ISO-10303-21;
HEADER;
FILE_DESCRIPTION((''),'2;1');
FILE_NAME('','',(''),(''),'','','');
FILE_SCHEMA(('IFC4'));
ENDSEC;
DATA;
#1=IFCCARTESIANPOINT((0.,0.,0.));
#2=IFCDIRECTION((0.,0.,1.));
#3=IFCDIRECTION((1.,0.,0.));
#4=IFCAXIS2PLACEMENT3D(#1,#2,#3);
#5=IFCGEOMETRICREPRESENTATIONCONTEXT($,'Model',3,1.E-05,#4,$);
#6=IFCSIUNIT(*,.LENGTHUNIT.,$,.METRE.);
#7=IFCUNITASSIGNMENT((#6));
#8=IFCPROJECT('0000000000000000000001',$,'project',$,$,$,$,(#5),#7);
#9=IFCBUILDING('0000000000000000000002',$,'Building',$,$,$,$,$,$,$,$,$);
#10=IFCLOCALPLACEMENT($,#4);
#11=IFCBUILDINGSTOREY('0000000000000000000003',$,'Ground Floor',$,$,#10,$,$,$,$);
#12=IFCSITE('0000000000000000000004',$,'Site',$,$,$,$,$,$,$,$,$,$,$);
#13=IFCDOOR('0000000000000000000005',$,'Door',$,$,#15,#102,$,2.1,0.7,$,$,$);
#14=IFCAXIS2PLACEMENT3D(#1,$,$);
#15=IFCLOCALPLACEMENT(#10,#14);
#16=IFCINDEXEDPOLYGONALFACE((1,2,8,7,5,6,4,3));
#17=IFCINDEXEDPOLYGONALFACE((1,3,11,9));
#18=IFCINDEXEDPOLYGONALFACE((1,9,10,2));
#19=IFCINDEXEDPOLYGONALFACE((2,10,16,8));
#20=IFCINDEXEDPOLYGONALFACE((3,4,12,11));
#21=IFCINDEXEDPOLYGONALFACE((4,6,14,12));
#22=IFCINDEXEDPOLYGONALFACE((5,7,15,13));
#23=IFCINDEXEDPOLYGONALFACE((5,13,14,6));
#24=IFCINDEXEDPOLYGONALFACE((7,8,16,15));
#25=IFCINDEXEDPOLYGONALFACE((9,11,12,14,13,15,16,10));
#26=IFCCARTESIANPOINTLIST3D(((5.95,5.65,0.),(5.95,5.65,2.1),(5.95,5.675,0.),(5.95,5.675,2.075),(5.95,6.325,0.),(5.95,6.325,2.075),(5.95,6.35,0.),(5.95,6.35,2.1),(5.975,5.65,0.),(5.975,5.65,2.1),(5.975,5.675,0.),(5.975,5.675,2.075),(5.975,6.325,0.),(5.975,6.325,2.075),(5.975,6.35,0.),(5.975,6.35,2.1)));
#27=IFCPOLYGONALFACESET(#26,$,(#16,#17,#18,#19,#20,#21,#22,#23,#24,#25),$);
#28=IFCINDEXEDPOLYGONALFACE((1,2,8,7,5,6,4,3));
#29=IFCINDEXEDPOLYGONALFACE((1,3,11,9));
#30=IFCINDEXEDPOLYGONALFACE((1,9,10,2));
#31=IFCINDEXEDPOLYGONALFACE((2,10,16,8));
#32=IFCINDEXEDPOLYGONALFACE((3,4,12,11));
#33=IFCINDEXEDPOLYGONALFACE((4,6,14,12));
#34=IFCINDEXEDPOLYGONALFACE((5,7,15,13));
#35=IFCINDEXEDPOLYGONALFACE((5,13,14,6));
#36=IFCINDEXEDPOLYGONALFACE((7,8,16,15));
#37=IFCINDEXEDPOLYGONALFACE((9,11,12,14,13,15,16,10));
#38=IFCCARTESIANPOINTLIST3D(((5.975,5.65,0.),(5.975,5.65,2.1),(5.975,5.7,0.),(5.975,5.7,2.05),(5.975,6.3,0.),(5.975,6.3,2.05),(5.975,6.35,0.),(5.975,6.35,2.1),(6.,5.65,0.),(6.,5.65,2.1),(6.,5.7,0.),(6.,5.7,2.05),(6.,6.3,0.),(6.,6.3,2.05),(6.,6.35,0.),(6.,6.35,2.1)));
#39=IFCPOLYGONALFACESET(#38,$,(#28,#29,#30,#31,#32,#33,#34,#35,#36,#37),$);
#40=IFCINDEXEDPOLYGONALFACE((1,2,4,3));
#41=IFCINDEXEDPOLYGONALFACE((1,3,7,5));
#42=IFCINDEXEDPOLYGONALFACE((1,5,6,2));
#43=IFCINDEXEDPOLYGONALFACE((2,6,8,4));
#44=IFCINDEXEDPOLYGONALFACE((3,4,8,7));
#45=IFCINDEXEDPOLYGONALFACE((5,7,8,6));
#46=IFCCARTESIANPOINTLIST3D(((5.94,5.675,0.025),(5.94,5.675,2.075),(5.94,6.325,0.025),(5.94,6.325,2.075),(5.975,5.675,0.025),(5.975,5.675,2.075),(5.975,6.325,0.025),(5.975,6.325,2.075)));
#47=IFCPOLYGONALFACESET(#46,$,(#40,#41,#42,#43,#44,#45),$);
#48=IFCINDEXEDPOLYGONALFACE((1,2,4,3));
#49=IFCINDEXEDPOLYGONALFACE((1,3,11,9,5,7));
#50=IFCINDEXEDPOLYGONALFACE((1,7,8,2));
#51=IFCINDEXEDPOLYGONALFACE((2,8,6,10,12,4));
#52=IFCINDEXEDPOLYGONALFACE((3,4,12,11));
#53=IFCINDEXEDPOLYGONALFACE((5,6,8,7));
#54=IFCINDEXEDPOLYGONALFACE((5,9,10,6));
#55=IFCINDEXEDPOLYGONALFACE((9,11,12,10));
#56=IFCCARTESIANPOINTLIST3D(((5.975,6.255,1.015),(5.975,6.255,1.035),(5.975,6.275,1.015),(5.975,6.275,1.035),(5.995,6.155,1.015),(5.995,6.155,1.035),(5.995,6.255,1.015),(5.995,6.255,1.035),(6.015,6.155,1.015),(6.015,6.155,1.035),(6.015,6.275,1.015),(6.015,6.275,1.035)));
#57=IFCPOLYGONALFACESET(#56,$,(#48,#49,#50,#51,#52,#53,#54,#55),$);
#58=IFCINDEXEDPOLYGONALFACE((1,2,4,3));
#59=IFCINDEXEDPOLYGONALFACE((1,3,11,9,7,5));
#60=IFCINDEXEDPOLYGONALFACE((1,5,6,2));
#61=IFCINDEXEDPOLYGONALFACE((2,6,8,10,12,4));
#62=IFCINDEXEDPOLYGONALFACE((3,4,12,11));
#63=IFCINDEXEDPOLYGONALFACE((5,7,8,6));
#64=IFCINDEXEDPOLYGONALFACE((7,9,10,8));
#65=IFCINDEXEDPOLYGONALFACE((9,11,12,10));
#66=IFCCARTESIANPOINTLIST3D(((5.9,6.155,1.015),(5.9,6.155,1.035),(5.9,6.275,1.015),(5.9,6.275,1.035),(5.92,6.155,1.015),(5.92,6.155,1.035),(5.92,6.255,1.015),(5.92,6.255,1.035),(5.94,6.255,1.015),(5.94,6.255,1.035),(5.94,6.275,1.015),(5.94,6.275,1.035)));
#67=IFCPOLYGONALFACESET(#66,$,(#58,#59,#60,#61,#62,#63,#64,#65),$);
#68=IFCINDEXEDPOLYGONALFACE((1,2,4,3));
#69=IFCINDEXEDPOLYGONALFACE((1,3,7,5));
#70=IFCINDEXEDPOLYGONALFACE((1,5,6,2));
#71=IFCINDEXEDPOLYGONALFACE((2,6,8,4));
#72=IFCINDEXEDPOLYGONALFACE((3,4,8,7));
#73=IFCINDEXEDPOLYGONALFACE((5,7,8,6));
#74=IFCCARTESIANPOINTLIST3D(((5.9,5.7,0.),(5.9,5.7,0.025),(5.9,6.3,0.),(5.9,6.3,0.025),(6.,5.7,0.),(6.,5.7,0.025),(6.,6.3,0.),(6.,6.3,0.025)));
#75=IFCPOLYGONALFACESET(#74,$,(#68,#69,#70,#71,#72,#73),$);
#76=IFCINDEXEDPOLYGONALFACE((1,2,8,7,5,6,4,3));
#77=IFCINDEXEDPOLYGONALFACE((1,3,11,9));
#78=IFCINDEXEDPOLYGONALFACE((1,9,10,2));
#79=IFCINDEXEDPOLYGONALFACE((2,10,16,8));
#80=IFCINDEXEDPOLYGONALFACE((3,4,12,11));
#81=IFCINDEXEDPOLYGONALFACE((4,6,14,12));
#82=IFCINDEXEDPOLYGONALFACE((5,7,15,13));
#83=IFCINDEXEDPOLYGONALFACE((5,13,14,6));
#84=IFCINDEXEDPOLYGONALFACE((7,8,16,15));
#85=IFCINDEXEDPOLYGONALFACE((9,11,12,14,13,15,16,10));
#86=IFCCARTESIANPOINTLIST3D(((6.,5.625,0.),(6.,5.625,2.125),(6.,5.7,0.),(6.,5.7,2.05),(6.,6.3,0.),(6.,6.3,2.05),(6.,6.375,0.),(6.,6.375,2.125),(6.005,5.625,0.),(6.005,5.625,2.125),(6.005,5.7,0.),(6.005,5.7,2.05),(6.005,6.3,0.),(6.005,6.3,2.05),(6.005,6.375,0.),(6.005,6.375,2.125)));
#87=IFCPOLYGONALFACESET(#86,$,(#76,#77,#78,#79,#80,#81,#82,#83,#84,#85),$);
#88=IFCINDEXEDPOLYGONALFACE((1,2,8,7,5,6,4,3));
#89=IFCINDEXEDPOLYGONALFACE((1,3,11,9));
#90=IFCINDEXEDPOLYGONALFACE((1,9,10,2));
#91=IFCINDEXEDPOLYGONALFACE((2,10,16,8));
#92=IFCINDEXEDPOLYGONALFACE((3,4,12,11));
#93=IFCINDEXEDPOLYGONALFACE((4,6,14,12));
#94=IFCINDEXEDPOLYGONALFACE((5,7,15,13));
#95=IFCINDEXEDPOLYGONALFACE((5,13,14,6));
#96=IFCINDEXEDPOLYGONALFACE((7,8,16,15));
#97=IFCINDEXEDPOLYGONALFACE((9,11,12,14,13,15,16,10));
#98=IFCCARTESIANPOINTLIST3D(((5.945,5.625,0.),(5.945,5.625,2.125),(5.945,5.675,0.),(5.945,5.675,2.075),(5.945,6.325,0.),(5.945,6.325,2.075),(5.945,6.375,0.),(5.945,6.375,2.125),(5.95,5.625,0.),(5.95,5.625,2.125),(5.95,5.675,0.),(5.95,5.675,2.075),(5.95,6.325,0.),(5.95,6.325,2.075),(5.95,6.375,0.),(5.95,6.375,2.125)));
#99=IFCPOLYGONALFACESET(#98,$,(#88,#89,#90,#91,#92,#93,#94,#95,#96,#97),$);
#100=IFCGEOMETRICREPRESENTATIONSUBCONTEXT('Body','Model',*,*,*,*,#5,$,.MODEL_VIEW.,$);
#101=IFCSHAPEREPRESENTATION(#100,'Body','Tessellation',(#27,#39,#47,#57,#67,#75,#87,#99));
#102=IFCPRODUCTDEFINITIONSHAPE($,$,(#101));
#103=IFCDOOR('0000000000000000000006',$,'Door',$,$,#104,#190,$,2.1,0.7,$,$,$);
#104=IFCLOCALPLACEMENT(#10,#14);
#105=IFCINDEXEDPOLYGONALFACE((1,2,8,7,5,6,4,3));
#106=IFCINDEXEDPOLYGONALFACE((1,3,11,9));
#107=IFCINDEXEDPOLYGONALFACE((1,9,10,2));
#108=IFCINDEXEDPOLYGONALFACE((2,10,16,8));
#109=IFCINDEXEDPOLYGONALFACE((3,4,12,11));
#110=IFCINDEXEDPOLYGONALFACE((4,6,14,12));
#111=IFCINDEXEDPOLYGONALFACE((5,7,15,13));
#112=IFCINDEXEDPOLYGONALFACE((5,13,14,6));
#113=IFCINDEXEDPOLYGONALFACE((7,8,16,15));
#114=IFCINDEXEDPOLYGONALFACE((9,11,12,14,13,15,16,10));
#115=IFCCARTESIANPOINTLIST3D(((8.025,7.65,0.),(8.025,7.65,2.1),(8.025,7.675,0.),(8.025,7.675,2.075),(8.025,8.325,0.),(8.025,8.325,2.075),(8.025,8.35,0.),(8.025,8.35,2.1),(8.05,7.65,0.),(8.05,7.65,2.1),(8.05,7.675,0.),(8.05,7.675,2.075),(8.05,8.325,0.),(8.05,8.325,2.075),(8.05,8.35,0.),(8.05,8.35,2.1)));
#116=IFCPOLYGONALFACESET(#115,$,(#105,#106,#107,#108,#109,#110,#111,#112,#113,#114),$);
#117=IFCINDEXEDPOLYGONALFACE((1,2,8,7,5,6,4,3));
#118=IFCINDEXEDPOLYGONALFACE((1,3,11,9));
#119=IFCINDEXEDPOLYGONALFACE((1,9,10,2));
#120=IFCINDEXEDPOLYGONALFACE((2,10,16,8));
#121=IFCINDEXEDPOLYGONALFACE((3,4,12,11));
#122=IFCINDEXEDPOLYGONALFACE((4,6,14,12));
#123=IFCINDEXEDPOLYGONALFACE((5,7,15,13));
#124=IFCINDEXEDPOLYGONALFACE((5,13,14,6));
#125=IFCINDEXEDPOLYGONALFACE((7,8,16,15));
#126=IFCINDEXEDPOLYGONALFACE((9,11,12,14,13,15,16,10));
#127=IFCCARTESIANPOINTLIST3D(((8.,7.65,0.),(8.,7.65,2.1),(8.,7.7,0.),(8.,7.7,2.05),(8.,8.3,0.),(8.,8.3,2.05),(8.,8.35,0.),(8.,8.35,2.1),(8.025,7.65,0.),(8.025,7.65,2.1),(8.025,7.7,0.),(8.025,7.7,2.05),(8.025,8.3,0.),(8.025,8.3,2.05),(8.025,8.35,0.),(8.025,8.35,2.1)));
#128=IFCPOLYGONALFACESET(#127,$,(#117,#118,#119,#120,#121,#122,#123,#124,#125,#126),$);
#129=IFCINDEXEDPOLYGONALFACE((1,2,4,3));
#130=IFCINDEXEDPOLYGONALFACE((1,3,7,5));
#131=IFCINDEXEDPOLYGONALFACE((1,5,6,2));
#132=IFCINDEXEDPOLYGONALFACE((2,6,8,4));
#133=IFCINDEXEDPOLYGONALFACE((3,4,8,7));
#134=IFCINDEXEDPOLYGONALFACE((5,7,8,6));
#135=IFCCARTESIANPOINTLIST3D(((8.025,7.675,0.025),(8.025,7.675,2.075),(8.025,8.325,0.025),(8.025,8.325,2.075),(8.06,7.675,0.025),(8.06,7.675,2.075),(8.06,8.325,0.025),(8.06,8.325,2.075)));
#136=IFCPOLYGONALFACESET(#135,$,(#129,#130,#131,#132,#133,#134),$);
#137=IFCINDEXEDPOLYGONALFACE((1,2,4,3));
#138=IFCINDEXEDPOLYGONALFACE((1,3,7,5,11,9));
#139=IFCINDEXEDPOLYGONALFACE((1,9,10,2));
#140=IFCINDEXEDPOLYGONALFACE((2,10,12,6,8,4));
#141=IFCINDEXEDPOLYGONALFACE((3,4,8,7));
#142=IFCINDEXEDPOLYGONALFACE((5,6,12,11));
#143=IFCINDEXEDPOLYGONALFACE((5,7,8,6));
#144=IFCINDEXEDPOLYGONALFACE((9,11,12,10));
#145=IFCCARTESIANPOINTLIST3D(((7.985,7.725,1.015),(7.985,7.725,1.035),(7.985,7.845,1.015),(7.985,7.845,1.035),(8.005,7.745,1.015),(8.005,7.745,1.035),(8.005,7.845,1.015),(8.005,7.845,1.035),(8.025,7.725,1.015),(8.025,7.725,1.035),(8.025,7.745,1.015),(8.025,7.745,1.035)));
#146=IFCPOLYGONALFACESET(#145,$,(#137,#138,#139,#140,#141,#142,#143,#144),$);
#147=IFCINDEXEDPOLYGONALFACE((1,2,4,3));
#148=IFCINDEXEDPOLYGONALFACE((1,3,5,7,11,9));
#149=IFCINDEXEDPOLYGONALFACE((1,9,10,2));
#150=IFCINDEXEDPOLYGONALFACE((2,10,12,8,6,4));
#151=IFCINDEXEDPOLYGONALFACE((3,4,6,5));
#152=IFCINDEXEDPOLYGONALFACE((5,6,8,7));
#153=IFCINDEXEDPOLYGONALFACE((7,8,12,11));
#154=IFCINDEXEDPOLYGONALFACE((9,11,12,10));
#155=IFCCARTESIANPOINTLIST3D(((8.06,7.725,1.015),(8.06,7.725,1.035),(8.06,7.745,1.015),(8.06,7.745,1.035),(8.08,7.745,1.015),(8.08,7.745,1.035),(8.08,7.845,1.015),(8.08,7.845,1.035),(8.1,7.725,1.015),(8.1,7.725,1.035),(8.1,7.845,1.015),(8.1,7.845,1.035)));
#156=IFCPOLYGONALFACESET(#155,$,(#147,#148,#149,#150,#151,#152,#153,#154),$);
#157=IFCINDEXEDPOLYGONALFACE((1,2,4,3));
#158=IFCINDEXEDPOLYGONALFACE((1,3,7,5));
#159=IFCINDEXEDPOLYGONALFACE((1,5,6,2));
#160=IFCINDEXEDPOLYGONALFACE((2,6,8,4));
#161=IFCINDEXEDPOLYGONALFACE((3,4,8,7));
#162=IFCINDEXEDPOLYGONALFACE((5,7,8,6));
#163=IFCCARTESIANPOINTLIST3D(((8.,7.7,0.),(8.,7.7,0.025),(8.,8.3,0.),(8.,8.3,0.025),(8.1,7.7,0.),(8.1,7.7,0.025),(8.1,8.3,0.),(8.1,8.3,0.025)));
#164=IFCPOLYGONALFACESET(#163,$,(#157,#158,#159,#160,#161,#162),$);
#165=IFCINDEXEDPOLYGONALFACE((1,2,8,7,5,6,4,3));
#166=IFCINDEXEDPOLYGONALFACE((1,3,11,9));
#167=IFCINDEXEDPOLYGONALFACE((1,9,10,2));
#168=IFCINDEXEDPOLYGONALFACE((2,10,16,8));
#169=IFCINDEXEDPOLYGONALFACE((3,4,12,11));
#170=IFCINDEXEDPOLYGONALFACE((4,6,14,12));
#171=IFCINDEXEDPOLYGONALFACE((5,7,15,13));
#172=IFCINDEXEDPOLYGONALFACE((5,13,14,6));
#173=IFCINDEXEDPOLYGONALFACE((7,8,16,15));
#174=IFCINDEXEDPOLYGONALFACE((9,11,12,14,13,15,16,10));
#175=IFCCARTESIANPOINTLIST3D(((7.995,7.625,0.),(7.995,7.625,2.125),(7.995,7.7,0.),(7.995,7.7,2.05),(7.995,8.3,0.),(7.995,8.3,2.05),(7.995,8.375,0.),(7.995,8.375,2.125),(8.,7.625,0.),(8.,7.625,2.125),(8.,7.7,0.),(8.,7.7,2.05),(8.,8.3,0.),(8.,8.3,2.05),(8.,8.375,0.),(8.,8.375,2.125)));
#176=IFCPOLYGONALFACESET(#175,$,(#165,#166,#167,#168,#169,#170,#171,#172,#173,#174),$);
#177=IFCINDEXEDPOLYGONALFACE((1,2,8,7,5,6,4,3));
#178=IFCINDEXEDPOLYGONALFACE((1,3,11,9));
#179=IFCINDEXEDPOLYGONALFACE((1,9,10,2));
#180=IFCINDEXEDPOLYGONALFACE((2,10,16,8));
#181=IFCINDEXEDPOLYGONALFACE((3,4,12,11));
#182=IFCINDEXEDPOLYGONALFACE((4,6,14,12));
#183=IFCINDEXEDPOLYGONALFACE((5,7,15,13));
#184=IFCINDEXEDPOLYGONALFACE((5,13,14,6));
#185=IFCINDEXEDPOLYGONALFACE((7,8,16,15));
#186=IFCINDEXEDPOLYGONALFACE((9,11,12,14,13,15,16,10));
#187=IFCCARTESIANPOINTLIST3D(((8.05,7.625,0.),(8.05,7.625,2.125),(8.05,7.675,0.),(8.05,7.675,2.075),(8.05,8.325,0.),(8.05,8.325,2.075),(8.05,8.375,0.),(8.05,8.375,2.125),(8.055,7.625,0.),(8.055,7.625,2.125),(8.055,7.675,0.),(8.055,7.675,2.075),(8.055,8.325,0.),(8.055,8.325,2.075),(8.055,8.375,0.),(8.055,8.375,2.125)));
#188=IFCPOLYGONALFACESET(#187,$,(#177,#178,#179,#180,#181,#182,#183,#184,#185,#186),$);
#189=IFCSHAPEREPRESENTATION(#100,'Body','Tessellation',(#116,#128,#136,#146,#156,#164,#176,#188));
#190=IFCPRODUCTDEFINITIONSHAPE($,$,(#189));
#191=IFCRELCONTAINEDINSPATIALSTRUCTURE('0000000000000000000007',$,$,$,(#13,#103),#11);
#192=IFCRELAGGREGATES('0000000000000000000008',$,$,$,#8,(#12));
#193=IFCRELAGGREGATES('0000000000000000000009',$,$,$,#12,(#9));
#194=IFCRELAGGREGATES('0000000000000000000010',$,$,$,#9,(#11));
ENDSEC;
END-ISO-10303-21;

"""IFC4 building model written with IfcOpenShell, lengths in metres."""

from ifc_helpers import new_model, si_unit, frame, origin_with_axes, place, context, subcontext, project, spatial, line, indexed_curve, outline, extrude, element, save


model = new_model("IFC4")

# Units and contexts
model_context = context("Model", 3, precision=1e-05, world=origin_with_axes())
body_context = subcontext(model_context, "Body", "Model", "MODEL_VIEW")
ifc_project = project(units=[si_unit("LENGTHUNIT", "METRE")], contexts=[model_context])

# Site, building, storey
site = spatial("IfcSite", under=ifc_project, Name="Site")
building = spatial("IfcBuilding", under=site, Name="Building")
storey_placement = place(None, origin_with_axes())
storey = spatial("IfcBuildingStorey", under=building, at=storey_placement, Name="Ground Floor")

# Doors
door_1_placement = place(storey_placement, frame((6.0, 5.65, 0.0), z_axis=(0.0, 0.0, 1.0), x_axis=(0.0, 1.0, 0.0)))
element("IfcDoor", 1, at=door_1_placement, inside=storey, Name="Door", OverallHeight=2.1, OverallWidth=0.7, context=body_context, shape_type="SweptSolid", body=[
    extrude(outline(indexed_curve([(0.0, 0.0), (0.0, 2.1), (0.7, 2.1), (0.7, 0.0), (0.675, 0.0), (0.675, 2.075), (0.025, 2.075), (0.025, 0.0)], segments=[line(1, 2, 3, 4, 5, 6, 7, 8, 1)])), frame((0.0, 0.025, 0.0), z_axis=(0.0, -1.0, 0.0), x_axis=(1.0, 0.0, 0.0)), (0.0, 0.0, -1.0), 0.025),
    extrude(outline(indexed_curve([(0.0, 0.0), (0.0, 2.1), (0.7, 2.1), (0.7, 0.0), (0.65, 0.0), (0.65, 2.05), (0.05, 2.05), (0.05, 0.0)], segments=[line(1, 2, 3, 4, 5, 6, 7, 8, 1)])), frame((0.0, 0.0, 0.0), z_axis=(0.0, -1.0, 0.0), x_axis=(1.0, 0.0, 0.0)), (0.0, 0.0, -1.0), 0.025),
    extrude(outline(indexed_curve([(0.0, 0.0), (0.65, 0.0), (0.65, 0.035), (0.0, 0.035)], segments=[line(1, 2, 3, 4, 1)])), frame((0.025, 0.025, 0.025), z_axis=(0.0, 0.0, 1.0), x_axis=(1.0, 0.0, 0.0)), (0.0, 0.0, 1.0), 2.05),
    extrude(outline(indexed_curve([(0.0, 0.0), (0.0, -0.04), (-0.12, -0.04), (-0.12, -0.02), (-0.02, -0.02), (-0.02, 0.0)], segments=[line(1, 2, 3, 4, 5, 6, 1)])), frame((0.625, 0.025, 1.015), z_axis=(0.0, 0.0, 1.0), x_axis=(1.0, 0.0, 0.0)), (0.0, 0.0, 1.0), 0.02),
    extrude(outline(indexed_curve([(0.0, 0.0), (0.0, 0.04), (-0.12, 0.04), (-0.12, 0.02), (-0.02, 0.02), (-0.02, 0.0)], segments=[line(1, 2, 3, 4, 5, 6, 1)])), frame((0.625, 0.06, 1.015), z_axis=(0.0, 0.0, 1.0), x_axis=(1.0, 0.0, 0.0)), (0.0, 0.0, 1.0), 0.02),
    extrude(outline(indexed_curve([(0.0, 0.0), (0.6, 0.0), (0.6, 0.1), (0.0, 0.1)], segments=[line(1, 2, 3, 4, 1)])), frame((0.05, 0.0, 0.0), z_axis=(0.0, 0.0, 1.0), x_axis=(1.0, 0.0, 0.0)), (0.0, 0.0, 1.0), 0.025),
    extrude(outline(indexed_curve([(0.0, 0.0), (0.0, 2.125), (0.75, 2.125), (0.75, 0.0), (0.675, 0.0), (0.675, 2.05), (0.075, 2.05), (0.075, 0.0)], segments=[line(1, 2, 3, 4, 5, 6, 7, 8, 1)])), frame((-0.025, -0.005, 0.0), z_axis=(0.0, -1.0, 0.0), x_axis=(1.0, 0.0, 0.0)), (0.0, 0.0, -1.0), 0.005),
    extrude(outline(indexed_curve([(0.0, 0.0), (0.0, 2.125), (0.75, 2.125), (0.75, 0.0), (0.7, 0.0), (0.7, 2.075), (0.05, 2.075), (0.05, 0.0)], segments=[line(1, 2, 3, 4, 5, 6, 7, 8, 1)])), frame((-0.025, 0.05, 0.0), z_axis=(0.0, -1.0, 0.0), x_axis=(1.0, 0.0, 0.0)), (0.0, 0.0, -1.0), 0.005),
])
door_2_placement = place(storey_placement, frame((8.0, 8.35, 0.0), z_axis=(0.0, 0.0, 1.0), x_axis=(0.0, -1.0, 0.0)))
element("IfcDoor", 2, at=door_2_placement, inside=storey, Name="Door", OverallHeight=2.1, OverallWidth=0.7, context=body_context, shape_type="SweptSolid", body=[
    extrude(outline(indexed_curve([(0.0, 0.0), (0.0, 2.1), (0.7, 2.1), (0.7, 0.0), (0.675, 0.0), (0.675, 2.075), (0.025, 2.075), (0.025, 0.0)], segments=[line(1, 2, 3, 4, 5, 6, 7, 8, 1)])), frame((0.0, 0.025, 0.0), z_axis=(0.0, -1.0, 0.0), x_axis=(1.0, 0.0, 0.0)), (0.0, 0.0, -1.0), 0.025),
    extrude(outline(indexed_curve([(0.0, 0.0), (0.0, 2.1), (0.7, 2.1), (0.7, 0.0), (0.65, 0.0), (0.65, 2.05), (0.05, 2.05), (0.05, 0.0)], segments=[line(1, 2, 3, 4, 5, 6, 7, 8, 1)])), frame((0.0, 0.0, 0.0), z_axis=(0.0, -1.0, 0.0), x_axis=(1.0, 0.0, 0.0)), (0.0, 0.0, -1.0), 0.025),
    extrude(outline(indexed_curve([(0.0, 0.0), (0.65, 0.0), (0.65, 0.035), (0.0, 0.035)], segments=[line(1, 2, 3, 4, 1)])), frame((0.025, 0.025, 0.025), z_axis=(0.0, 0.0, 1.0), x_axis=(1.0, 0.0, 0.0)), (0.0, 0.0, 1.0), 2.05),
    extrude(outline(indexed_curve([(0.0, 0.0), (0.0, -0.04), (-0.12, -0.04), (-0.12, -0.02), (-0.02, -0.02), (-0.02, 0.0)], segments=[line(1, 2, 3, 4, 5, 6, 1)])), frame((0.625, 0.025, 1.015), z_axis=(0.0, 0.0, 1.0), x_axis=(1.0, 0.0, 0.0)), (0.0, 0.0, 1.0), 0.02),
    extrude(outline(indexed_curve([(0.0, 0.0), (0.0, 0.04), (-0.12, 0.04), (-0.12, 0.02), (-0.02, 0.02), (-0.02, 0.0)], segments=[line(1, 2, 3, 4, 5, 6, 1)])), frame((0.625, 0.06, 1.015), z_axis=(0.0, 0.0, 1.0), x_axis=(1.0, 0.0, 0.0)), (0.0, 0.0, 1.0), 0.02),
    extrude(outline(indexed_curve([(0.0, 0.0), (0.6, 0.0), (0.6, 0.1), (0.0, 0.1)], segments=[line(1, 2, 3, 4, 1)])), frame((0.05, 0.0, 0.0), z_axis=(0.0, 0.0, 1.0), x_axis=(1.0, 0.0, 0.0)), (0.0, 0.0, 1.0), 0.025),
    extrude(outline(indexed_curve([(0.0, 0.0), (0.0, 2.125), (0.75, 2.125), (0.75, 0.0), (0.675, 0.0), (0.675, 2.05), (0.075, 2.05), (0.075, 0.0)], segments=[line(1, 2, 3, 4, 5, 6, 7, 8, 1)])), frame((-0.025, -0.005, 0.0), z_axis=(0.0, -1.0, 0.0), x_axis=(1.0, 0.0, 0.0)), (0.0, 0.0, -1.0), 0.005),
    extrude(outline(indexed_curve([(0.0, 0.0), (0.0, 2.125), (0.75, 2.125), (0.75, 0.0), (0.7, 0.0), (0.7, 2.075), (0.05, 2.075), (0.05, 0.0)], segments=[line(1, 2, 3, 4, 5, 6, 7, 8, 1)])), frame((-0.025, 0.05, 0.0), z_axis=(0.0, -1.0, 0.0), x_axis=(1.0, 0.0, 0.0)), (0.0, 0.0, -1.0), 0.005),
])

save(model, "model.ifc")
